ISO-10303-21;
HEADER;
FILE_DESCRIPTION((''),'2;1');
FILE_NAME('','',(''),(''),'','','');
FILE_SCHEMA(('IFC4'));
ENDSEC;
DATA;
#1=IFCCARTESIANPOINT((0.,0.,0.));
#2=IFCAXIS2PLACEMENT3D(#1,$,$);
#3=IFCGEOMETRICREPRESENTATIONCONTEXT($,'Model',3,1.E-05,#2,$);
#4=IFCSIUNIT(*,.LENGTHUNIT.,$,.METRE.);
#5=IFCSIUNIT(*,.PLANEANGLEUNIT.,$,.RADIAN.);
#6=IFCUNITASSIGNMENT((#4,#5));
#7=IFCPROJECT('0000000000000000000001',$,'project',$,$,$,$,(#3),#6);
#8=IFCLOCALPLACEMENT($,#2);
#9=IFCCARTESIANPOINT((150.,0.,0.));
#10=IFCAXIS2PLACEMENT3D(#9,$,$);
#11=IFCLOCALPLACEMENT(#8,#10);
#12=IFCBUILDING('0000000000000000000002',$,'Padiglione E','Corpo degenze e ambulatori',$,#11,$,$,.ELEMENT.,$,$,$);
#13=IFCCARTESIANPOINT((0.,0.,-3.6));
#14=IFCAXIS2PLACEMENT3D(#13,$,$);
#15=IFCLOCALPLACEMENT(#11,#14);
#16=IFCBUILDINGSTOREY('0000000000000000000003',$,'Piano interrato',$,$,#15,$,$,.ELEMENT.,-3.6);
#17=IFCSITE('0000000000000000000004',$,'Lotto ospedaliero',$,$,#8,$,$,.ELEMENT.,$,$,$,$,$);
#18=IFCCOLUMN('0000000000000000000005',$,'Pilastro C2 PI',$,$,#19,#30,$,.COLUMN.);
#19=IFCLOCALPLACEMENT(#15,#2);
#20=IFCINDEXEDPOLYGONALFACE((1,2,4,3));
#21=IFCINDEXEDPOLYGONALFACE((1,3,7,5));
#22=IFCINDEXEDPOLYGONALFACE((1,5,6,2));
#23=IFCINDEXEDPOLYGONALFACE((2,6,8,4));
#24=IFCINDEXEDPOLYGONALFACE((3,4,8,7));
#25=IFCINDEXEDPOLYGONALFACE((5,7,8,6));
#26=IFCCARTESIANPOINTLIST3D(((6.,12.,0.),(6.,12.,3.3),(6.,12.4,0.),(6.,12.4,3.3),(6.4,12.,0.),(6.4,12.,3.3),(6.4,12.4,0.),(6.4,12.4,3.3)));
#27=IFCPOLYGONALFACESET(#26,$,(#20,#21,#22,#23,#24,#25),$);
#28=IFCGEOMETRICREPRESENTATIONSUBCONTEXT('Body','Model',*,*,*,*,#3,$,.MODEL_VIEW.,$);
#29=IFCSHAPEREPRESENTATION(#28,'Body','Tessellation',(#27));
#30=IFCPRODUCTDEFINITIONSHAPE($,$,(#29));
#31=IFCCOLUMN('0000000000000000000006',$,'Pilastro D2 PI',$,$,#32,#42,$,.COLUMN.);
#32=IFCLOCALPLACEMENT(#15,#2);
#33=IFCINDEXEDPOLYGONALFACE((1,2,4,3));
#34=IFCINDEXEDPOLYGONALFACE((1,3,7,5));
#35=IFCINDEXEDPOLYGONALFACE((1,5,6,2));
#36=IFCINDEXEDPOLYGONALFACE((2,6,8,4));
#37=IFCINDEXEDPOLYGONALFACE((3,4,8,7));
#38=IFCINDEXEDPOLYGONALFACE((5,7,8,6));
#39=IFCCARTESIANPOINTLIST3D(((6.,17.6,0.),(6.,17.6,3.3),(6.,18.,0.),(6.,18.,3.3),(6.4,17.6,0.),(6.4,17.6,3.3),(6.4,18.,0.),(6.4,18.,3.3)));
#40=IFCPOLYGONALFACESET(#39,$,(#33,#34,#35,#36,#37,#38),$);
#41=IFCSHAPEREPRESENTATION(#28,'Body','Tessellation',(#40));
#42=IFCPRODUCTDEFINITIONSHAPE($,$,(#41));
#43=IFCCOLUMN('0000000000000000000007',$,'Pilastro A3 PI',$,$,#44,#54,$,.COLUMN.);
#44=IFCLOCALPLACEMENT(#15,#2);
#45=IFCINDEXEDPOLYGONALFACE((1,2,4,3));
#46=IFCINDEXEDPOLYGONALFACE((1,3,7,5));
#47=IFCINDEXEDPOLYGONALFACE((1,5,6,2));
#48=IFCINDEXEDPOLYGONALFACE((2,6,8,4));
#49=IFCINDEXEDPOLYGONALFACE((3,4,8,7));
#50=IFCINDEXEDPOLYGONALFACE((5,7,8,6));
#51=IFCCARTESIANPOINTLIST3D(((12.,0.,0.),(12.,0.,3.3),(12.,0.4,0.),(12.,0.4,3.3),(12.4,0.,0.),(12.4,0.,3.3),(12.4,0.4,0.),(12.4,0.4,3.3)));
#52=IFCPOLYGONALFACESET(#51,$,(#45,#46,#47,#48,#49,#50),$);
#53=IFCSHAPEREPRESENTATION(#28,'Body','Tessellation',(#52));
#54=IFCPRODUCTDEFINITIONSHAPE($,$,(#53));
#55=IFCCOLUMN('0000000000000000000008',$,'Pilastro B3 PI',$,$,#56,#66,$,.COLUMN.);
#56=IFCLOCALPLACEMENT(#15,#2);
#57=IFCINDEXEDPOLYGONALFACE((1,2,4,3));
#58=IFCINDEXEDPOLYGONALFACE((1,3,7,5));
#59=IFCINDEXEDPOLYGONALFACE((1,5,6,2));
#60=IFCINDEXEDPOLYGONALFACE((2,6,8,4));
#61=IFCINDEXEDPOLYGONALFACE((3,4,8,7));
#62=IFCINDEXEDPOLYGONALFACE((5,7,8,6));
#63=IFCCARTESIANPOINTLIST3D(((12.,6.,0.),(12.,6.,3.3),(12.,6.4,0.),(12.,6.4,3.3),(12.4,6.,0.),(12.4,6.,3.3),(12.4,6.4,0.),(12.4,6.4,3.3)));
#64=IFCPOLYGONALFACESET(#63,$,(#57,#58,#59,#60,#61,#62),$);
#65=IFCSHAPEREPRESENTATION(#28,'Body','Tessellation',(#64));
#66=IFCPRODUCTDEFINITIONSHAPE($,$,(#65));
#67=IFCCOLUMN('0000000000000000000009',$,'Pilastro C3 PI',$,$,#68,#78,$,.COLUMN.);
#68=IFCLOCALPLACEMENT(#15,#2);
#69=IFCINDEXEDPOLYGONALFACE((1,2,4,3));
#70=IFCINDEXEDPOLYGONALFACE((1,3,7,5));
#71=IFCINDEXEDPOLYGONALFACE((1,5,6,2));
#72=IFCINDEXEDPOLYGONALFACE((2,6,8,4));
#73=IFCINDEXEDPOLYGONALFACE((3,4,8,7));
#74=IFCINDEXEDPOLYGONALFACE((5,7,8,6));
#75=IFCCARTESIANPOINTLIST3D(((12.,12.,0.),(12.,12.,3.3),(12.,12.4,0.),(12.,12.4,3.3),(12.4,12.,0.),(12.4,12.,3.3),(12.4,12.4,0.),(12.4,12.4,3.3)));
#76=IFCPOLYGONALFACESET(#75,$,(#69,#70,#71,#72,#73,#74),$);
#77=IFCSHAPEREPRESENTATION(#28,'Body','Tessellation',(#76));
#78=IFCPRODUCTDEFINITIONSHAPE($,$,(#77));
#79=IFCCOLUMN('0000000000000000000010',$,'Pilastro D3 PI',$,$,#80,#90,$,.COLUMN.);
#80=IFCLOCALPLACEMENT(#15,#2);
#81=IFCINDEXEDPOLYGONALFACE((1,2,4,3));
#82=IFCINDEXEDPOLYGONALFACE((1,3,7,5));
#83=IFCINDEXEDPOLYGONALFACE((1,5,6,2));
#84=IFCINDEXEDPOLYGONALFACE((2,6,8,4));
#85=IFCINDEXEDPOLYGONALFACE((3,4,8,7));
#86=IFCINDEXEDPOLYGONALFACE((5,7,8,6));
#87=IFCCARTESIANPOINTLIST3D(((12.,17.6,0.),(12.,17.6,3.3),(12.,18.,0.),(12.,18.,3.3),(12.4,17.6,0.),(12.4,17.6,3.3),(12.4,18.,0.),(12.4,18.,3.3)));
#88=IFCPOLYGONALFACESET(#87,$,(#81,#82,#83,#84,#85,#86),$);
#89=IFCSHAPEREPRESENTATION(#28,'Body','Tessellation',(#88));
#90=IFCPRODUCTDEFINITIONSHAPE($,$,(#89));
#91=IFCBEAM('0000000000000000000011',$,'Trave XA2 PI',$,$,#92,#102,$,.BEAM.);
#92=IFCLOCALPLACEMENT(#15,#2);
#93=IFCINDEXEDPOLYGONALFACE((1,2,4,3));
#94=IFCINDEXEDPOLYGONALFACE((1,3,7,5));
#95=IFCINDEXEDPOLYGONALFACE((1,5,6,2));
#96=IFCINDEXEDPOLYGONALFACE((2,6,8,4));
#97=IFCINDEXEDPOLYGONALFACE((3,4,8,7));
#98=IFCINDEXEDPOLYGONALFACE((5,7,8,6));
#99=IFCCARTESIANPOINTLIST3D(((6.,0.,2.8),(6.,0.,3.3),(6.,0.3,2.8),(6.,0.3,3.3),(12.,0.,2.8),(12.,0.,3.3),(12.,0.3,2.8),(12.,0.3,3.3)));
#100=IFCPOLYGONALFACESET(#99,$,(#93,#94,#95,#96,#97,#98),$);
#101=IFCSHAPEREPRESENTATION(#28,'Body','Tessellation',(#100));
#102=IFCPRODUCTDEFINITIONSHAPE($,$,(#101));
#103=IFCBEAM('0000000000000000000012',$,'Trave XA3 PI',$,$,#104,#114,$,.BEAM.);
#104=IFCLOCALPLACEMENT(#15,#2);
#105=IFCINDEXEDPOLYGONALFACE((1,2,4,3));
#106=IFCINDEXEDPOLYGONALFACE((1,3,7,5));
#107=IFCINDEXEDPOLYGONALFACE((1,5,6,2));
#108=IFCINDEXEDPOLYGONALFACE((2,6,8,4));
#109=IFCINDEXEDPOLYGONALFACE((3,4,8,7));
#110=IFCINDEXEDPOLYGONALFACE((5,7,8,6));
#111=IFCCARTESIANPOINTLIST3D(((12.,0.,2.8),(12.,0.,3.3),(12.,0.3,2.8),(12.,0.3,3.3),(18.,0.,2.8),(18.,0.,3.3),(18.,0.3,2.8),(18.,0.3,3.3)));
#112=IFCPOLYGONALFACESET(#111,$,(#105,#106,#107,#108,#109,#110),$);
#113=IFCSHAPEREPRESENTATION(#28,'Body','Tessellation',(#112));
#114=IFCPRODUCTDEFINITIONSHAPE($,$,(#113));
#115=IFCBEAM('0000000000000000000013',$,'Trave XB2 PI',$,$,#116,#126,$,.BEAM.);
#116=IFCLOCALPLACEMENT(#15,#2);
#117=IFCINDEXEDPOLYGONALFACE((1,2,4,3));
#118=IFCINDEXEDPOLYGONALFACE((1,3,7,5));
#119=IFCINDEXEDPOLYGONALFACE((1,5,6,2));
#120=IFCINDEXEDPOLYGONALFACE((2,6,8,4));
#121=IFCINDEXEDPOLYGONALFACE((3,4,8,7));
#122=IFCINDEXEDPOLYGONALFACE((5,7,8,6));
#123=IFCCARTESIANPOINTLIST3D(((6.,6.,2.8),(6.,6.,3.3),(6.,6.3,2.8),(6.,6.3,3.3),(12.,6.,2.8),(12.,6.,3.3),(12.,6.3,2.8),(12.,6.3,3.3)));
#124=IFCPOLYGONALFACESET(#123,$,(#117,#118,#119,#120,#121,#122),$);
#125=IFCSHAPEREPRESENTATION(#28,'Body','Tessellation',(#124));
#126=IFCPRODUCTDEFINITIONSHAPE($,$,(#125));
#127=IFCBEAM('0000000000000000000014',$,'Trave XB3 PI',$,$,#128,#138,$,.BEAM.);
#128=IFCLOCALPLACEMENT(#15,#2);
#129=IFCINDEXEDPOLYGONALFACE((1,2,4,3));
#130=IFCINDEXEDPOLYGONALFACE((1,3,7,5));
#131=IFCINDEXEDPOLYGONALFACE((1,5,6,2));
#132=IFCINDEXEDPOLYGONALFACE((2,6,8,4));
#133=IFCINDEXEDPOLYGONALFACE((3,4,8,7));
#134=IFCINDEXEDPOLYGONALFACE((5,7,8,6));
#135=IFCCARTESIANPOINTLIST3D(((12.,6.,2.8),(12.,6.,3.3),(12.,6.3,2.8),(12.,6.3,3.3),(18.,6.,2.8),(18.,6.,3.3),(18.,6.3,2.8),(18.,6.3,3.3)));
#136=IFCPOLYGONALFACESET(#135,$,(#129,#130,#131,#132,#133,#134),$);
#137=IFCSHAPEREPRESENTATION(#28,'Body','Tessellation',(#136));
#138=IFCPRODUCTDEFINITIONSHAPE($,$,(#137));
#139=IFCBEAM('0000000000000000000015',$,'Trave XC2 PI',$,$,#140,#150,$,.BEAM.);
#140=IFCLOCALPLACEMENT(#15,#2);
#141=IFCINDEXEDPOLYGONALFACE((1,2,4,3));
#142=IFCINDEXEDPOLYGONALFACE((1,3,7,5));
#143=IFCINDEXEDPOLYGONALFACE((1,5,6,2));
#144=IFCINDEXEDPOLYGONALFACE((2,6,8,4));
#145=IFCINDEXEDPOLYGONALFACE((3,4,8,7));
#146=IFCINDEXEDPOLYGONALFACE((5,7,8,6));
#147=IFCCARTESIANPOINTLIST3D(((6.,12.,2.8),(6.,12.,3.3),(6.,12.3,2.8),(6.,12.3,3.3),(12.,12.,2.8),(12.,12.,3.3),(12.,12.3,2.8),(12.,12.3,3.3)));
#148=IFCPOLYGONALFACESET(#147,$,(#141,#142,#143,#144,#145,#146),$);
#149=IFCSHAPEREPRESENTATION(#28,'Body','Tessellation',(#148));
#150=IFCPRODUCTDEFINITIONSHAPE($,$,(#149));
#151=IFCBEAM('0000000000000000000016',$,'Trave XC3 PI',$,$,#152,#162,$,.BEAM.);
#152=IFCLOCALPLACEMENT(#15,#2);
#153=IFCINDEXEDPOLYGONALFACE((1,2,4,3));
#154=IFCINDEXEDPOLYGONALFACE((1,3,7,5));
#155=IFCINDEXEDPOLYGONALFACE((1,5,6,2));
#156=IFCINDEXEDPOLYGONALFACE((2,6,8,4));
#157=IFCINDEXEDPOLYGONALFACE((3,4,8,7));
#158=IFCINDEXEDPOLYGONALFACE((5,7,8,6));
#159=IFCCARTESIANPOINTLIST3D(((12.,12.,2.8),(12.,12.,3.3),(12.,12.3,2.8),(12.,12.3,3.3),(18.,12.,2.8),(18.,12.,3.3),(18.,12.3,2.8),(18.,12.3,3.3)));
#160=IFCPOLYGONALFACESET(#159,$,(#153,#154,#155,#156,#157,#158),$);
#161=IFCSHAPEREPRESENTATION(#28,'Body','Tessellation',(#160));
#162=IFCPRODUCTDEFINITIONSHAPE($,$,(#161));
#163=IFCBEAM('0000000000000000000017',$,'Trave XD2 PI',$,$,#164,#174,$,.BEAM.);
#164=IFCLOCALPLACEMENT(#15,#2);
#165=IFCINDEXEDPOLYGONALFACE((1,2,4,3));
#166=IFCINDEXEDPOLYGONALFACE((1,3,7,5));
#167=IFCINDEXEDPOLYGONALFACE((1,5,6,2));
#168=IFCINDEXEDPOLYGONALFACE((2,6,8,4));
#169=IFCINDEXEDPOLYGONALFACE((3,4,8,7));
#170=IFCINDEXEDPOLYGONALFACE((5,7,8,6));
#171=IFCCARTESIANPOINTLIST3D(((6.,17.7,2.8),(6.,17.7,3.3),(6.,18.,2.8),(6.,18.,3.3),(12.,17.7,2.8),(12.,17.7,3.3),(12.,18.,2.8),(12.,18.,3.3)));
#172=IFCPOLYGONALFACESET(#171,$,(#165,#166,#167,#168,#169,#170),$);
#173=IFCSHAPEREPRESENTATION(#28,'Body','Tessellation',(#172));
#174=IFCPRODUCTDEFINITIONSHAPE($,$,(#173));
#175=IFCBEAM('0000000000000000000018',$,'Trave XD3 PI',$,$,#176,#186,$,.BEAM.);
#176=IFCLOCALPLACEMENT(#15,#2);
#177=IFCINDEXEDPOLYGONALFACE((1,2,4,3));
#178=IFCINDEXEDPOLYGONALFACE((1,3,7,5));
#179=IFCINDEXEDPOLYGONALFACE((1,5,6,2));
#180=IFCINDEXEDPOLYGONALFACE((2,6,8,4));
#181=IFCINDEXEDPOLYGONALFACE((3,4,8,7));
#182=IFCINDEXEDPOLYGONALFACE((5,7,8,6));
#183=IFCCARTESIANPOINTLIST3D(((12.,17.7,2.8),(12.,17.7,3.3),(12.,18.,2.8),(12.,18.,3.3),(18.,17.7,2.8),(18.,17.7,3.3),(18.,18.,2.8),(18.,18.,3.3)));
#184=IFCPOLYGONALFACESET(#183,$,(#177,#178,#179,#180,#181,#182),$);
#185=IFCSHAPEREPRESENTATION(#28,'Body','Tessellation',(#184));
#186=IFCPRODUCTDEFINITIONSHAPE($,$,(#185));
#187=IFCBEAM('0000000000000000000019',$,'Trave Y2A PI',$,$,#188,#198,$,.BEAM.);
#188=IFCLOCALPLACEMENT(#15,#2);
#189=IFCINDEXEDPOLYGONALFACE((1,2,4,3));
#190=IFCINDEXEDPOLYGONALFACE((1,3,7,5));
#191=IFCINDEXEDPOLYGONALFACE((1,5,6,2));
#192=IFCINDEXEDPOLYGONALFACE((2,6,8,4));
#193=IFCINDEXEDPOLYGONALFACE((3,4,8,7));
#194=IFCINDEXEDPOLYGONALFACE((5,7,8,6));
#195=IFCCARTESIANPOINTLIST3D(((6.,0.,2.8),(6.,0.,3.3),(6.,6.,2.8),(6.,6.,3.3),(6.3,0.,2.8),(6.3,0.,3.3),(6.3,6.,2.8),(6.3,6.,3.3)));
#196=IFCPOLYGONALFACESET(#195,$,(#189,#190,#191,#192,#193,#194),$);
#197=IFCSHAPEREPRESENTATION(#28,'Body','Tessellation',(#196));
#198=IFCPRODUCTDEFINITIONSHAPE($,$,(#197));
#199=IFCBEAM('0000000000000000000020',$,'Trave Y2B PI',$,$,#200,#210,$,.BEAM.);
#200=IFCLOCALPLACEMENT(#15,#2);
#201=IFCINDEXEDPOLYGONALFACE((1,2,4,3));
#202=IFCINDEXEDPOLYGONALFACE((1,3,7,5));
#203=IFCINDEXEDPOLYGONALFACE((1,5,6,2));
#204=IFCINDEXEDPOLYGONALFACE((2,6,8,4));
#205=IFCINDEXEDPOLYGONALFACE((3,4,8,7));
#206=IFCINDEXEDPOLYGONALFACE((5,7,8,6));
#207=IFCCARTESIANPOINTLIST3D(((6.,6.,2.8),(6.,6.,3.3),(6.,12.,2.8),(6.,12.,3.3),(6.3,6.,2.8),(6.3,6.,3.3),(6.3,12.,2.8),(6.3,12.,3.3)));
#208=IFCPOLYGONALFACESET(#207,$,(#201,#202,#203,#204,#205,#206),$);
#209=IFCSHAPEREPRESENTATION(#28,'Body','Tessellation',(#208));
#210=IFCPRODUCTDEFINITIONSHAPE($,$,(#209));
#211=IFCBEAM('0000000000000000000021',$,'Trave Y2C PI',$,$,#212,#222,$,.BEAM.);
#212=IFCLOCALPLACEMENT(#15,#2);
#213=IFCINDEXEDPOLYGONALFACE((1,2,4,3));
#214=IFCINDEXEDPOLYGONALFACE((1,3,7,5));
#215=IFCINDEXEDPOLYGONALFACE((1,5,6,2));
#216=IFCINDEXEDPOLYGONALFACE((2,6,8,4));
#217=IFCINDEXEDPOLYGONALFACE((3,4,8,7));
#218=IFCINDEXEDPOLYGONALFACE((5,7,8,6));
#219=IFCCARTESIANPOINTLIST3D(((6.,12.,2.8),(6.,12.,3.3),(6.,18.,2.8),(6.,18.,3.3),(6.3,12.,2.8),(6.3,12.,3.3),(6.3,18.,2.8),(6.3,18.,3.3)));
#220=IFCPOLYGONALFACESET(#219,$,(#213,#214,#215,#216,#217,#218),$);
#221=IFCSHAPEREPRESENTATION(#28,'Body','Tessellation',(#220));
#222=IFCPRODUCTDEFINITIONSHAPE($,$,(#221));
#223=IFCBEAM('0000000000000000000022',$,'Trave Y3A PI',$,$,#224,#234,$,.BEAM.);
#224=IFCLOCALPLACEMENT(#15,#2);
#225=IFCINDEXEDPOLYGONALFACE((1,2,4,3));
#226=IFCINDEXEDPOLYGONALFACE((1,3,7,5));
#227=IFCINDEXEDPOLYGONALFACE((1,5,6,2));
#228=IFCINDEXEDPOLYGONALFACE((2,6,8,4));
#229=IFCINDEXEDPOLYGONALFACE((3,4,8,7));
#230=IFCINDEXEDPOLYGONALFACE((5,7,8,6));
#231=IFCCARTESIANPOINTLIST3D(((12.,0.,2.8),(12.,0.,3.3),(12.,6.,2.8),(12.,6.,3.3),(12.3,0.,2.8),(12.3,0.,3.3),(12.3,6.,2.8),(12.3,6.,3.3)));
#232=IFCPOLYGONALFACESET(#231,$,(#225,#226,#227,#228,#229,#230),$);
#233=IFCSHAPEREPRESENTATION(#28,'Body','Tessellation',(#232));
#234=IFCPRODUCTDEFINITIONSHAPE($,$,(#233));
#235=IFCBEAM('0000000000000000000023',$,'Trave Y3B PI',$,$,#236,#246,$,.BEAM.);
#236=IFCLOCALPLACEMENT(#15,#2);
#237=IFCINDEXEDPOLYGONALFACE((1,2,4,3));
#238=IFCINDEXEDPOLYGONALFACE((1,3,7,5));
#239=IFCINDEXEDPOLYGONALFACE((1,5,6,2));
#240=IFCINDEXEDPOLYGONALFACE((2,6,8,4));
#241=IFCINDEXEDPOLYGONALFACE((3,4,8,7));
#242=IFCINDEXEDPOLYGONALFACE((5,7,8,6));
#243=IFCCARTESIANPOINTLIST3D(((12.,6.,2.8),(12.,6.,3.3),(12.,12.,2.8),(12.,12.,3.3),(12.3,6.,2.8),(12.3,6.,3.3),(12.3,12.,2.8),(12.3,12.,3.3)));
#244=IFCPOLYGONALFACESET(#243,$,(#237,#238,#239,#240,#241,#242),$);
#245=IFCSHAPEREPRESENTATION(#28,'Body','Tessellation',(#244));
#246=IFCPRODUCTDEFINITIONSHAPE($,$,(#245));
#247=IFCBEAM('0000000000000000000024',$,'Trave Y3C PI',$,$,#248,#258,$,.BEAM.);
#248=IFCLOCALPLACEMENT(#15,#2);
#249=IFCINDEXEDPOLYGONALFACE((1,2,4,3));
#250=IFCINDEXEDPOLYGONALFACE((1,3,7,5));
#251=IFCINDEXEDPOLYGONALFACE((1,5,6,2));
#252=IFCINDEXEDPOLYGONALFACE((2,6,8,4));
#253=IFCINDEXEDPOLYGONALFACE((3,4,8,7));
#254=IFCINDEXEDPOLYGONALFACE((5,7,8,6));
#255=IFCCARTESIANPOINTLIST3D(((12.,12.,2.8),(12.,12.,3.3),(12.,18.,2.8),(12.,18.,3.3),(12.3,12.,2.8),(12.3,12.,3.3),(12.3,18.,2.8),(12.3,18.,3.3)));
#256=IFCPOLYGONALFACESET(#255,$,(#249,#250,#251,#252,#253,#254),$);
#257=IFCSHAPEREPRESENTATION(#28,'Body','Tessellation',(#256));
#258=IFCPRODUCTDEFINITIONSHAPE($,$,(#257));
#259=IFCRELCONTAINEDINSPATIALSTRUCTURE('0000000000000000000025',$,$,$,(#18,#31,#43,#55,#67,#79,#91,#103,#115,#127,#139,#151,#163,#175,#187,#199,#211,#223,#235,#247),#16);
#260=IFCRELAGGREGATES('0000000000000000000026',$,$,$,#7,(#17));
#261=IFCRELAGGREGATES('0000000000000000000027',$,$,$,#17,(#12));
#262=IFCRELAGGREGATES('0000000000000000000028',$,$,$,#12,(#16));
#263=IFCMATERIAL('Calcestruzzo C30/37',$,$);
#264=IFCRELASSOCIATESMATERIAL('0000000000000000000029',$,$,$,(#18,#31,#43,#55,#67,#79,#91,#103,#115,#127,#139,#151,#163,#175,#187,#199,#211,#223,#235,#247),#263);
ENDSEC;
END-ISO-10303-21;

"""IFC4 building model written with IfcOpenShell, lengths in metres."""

from ifc_helpers import new_model, si_unit, frame, frame_2d, origin, place, context, subcontext, project, spatial, rectangle, extrude, material, element, save


model = new_model("IFC4")

# Units and contexts
model_context = context("Model", 3, precision=1e-05, world=origin())
body_context = subcontext(model_context, "Body", "Model", "MODEL_VIEW")
ifc_project = project(units=[si_unit("LENGTHUNIT", "METRE"), si_unit("PLANEANGLEUNIT", "RADIAN")], contexts=[model_context])

# Site, building, storey
site_placement = place(None, origin())
site = spatial("IfcSite", under=ifc_project, at=site_placement, Name="Lotto ospedaliero", CompositionType="ELEMENT")
building_placement = place(site_placement, frame((150.0, 0.0, 0.0)))
building = spatial("IfcBuilding", under=site, at=building_placement, Name="Padiglione E", Description="Corpo degenze e ambulatori", CompositionType="ELEMENT")
storey_placement = place(building_placement, frame((0.0, 0.0, -3.6)))
storey = spatial("IfcBuildingStorey", under=building, at=storey_placement, Name="Piano interrato", CompositionType="ELEMENT", Elevation=-3.6)

# Columns
ifc_material_1 = material(Name="Calcestruzzo C30/37")
for number, where, name in (
    (1, (6.0, 12.0, 0.0), "Pilastro C2 PI"),
    (2, (6.0, 17.6, 0.0), "Pilastro D2 PI"),
    (3, (12.0, 0.0, 0.0), "Pilastro A3 PI"),
    (4, (12.0, 6.0, 0.0), "Pilastro B3 PI"),
    (5, (12.0, 12.0, 0.0), "Pilastro C3 PI"),
    (6, (12.0, 17.6, 0.0), "Pilastro D3 PI"),
):
    element("IfcColumn", number, at=place(storey_placement, frame(where)), inside=storey, material=ifc_material_1, Name=name, PredefinedType="COLUMN", context=body_context, shape_type="SweptSolid", body=[
        extrude(rectangle(XDim=0.4, YDim=0.4, at=frame_2d((0.2, 0.2))), origin(), (0.0, 0.0, 1.0), 3.3),
    ])

# Beams
for number, where, name in (
    (7, (6.0, 0.0, 2.8), "Trave XA2 PI"),
    (8, (12.0, 0.0, 2.8), "Trave XA3 PI"),
    (9, (6.0, 6.0, 2.8), "Trave XB2 PI"),
    (10, (12.0, 6.0, 2.8), "Trave XB3 PI"),
    (11, (6.0, 12.0, 2.8), "Trave XC2 PI"),
    (12, (12.0, 12.0, 2.8), "Trave XC3 PI"),
    (13, (6.0, 17.7, 2.8), "Trave XD2 PI"),
    (14, (12.0, 17.7, 2.8), "Trave XD3 PI"),
):
    element("IfcBeam", number, at=place(storey_placement, frame(where)), inside=storey, material=ifc_material_1, Name=name, PredefinedType="BEAM", context=body_context, shape_type="SweptSolid", body=[
        extrude(rectangle(XDim=6.0, YDim=0.3, at=frame_2d((3.0, 0.15))), origin(), (0.0, 0.0, 1.0), 0.5),
    ])
for number, where, name in (
    (15, (6.0, 0.0, 2.8), "Trave Y2A PI"),
    (16, (6.0, 6.0, 2.8), "Trave Y2B PI"),
    (17, (6.0, 12.0, 2.8), "Trave Y2C PI"),
    (18, (12.0, 0.0, 2.8), "Trave Y3A PI"),
    (19, (12.0, 6.0, 2.8), "Trave Y3B PI"),
    (20, (12.0, 12.0, 2.8), "Trave Y3C PI"),
):
    element("IfcBeam", number, at=place(storey_placement, frame(where)), inside=storey, material=ifc_material_1, Name=name, PredefinedType="BEAM", context=body_context, shape_type="SweptSolid", body=[
        extrude(rectangle(XDim=0.3, YDim=6.0, at=frame_2d((0.15, 3.0))), origin(), (0.0, 0.0, 1.0), 0.5),
    ])

save(model, "model.ifc")
